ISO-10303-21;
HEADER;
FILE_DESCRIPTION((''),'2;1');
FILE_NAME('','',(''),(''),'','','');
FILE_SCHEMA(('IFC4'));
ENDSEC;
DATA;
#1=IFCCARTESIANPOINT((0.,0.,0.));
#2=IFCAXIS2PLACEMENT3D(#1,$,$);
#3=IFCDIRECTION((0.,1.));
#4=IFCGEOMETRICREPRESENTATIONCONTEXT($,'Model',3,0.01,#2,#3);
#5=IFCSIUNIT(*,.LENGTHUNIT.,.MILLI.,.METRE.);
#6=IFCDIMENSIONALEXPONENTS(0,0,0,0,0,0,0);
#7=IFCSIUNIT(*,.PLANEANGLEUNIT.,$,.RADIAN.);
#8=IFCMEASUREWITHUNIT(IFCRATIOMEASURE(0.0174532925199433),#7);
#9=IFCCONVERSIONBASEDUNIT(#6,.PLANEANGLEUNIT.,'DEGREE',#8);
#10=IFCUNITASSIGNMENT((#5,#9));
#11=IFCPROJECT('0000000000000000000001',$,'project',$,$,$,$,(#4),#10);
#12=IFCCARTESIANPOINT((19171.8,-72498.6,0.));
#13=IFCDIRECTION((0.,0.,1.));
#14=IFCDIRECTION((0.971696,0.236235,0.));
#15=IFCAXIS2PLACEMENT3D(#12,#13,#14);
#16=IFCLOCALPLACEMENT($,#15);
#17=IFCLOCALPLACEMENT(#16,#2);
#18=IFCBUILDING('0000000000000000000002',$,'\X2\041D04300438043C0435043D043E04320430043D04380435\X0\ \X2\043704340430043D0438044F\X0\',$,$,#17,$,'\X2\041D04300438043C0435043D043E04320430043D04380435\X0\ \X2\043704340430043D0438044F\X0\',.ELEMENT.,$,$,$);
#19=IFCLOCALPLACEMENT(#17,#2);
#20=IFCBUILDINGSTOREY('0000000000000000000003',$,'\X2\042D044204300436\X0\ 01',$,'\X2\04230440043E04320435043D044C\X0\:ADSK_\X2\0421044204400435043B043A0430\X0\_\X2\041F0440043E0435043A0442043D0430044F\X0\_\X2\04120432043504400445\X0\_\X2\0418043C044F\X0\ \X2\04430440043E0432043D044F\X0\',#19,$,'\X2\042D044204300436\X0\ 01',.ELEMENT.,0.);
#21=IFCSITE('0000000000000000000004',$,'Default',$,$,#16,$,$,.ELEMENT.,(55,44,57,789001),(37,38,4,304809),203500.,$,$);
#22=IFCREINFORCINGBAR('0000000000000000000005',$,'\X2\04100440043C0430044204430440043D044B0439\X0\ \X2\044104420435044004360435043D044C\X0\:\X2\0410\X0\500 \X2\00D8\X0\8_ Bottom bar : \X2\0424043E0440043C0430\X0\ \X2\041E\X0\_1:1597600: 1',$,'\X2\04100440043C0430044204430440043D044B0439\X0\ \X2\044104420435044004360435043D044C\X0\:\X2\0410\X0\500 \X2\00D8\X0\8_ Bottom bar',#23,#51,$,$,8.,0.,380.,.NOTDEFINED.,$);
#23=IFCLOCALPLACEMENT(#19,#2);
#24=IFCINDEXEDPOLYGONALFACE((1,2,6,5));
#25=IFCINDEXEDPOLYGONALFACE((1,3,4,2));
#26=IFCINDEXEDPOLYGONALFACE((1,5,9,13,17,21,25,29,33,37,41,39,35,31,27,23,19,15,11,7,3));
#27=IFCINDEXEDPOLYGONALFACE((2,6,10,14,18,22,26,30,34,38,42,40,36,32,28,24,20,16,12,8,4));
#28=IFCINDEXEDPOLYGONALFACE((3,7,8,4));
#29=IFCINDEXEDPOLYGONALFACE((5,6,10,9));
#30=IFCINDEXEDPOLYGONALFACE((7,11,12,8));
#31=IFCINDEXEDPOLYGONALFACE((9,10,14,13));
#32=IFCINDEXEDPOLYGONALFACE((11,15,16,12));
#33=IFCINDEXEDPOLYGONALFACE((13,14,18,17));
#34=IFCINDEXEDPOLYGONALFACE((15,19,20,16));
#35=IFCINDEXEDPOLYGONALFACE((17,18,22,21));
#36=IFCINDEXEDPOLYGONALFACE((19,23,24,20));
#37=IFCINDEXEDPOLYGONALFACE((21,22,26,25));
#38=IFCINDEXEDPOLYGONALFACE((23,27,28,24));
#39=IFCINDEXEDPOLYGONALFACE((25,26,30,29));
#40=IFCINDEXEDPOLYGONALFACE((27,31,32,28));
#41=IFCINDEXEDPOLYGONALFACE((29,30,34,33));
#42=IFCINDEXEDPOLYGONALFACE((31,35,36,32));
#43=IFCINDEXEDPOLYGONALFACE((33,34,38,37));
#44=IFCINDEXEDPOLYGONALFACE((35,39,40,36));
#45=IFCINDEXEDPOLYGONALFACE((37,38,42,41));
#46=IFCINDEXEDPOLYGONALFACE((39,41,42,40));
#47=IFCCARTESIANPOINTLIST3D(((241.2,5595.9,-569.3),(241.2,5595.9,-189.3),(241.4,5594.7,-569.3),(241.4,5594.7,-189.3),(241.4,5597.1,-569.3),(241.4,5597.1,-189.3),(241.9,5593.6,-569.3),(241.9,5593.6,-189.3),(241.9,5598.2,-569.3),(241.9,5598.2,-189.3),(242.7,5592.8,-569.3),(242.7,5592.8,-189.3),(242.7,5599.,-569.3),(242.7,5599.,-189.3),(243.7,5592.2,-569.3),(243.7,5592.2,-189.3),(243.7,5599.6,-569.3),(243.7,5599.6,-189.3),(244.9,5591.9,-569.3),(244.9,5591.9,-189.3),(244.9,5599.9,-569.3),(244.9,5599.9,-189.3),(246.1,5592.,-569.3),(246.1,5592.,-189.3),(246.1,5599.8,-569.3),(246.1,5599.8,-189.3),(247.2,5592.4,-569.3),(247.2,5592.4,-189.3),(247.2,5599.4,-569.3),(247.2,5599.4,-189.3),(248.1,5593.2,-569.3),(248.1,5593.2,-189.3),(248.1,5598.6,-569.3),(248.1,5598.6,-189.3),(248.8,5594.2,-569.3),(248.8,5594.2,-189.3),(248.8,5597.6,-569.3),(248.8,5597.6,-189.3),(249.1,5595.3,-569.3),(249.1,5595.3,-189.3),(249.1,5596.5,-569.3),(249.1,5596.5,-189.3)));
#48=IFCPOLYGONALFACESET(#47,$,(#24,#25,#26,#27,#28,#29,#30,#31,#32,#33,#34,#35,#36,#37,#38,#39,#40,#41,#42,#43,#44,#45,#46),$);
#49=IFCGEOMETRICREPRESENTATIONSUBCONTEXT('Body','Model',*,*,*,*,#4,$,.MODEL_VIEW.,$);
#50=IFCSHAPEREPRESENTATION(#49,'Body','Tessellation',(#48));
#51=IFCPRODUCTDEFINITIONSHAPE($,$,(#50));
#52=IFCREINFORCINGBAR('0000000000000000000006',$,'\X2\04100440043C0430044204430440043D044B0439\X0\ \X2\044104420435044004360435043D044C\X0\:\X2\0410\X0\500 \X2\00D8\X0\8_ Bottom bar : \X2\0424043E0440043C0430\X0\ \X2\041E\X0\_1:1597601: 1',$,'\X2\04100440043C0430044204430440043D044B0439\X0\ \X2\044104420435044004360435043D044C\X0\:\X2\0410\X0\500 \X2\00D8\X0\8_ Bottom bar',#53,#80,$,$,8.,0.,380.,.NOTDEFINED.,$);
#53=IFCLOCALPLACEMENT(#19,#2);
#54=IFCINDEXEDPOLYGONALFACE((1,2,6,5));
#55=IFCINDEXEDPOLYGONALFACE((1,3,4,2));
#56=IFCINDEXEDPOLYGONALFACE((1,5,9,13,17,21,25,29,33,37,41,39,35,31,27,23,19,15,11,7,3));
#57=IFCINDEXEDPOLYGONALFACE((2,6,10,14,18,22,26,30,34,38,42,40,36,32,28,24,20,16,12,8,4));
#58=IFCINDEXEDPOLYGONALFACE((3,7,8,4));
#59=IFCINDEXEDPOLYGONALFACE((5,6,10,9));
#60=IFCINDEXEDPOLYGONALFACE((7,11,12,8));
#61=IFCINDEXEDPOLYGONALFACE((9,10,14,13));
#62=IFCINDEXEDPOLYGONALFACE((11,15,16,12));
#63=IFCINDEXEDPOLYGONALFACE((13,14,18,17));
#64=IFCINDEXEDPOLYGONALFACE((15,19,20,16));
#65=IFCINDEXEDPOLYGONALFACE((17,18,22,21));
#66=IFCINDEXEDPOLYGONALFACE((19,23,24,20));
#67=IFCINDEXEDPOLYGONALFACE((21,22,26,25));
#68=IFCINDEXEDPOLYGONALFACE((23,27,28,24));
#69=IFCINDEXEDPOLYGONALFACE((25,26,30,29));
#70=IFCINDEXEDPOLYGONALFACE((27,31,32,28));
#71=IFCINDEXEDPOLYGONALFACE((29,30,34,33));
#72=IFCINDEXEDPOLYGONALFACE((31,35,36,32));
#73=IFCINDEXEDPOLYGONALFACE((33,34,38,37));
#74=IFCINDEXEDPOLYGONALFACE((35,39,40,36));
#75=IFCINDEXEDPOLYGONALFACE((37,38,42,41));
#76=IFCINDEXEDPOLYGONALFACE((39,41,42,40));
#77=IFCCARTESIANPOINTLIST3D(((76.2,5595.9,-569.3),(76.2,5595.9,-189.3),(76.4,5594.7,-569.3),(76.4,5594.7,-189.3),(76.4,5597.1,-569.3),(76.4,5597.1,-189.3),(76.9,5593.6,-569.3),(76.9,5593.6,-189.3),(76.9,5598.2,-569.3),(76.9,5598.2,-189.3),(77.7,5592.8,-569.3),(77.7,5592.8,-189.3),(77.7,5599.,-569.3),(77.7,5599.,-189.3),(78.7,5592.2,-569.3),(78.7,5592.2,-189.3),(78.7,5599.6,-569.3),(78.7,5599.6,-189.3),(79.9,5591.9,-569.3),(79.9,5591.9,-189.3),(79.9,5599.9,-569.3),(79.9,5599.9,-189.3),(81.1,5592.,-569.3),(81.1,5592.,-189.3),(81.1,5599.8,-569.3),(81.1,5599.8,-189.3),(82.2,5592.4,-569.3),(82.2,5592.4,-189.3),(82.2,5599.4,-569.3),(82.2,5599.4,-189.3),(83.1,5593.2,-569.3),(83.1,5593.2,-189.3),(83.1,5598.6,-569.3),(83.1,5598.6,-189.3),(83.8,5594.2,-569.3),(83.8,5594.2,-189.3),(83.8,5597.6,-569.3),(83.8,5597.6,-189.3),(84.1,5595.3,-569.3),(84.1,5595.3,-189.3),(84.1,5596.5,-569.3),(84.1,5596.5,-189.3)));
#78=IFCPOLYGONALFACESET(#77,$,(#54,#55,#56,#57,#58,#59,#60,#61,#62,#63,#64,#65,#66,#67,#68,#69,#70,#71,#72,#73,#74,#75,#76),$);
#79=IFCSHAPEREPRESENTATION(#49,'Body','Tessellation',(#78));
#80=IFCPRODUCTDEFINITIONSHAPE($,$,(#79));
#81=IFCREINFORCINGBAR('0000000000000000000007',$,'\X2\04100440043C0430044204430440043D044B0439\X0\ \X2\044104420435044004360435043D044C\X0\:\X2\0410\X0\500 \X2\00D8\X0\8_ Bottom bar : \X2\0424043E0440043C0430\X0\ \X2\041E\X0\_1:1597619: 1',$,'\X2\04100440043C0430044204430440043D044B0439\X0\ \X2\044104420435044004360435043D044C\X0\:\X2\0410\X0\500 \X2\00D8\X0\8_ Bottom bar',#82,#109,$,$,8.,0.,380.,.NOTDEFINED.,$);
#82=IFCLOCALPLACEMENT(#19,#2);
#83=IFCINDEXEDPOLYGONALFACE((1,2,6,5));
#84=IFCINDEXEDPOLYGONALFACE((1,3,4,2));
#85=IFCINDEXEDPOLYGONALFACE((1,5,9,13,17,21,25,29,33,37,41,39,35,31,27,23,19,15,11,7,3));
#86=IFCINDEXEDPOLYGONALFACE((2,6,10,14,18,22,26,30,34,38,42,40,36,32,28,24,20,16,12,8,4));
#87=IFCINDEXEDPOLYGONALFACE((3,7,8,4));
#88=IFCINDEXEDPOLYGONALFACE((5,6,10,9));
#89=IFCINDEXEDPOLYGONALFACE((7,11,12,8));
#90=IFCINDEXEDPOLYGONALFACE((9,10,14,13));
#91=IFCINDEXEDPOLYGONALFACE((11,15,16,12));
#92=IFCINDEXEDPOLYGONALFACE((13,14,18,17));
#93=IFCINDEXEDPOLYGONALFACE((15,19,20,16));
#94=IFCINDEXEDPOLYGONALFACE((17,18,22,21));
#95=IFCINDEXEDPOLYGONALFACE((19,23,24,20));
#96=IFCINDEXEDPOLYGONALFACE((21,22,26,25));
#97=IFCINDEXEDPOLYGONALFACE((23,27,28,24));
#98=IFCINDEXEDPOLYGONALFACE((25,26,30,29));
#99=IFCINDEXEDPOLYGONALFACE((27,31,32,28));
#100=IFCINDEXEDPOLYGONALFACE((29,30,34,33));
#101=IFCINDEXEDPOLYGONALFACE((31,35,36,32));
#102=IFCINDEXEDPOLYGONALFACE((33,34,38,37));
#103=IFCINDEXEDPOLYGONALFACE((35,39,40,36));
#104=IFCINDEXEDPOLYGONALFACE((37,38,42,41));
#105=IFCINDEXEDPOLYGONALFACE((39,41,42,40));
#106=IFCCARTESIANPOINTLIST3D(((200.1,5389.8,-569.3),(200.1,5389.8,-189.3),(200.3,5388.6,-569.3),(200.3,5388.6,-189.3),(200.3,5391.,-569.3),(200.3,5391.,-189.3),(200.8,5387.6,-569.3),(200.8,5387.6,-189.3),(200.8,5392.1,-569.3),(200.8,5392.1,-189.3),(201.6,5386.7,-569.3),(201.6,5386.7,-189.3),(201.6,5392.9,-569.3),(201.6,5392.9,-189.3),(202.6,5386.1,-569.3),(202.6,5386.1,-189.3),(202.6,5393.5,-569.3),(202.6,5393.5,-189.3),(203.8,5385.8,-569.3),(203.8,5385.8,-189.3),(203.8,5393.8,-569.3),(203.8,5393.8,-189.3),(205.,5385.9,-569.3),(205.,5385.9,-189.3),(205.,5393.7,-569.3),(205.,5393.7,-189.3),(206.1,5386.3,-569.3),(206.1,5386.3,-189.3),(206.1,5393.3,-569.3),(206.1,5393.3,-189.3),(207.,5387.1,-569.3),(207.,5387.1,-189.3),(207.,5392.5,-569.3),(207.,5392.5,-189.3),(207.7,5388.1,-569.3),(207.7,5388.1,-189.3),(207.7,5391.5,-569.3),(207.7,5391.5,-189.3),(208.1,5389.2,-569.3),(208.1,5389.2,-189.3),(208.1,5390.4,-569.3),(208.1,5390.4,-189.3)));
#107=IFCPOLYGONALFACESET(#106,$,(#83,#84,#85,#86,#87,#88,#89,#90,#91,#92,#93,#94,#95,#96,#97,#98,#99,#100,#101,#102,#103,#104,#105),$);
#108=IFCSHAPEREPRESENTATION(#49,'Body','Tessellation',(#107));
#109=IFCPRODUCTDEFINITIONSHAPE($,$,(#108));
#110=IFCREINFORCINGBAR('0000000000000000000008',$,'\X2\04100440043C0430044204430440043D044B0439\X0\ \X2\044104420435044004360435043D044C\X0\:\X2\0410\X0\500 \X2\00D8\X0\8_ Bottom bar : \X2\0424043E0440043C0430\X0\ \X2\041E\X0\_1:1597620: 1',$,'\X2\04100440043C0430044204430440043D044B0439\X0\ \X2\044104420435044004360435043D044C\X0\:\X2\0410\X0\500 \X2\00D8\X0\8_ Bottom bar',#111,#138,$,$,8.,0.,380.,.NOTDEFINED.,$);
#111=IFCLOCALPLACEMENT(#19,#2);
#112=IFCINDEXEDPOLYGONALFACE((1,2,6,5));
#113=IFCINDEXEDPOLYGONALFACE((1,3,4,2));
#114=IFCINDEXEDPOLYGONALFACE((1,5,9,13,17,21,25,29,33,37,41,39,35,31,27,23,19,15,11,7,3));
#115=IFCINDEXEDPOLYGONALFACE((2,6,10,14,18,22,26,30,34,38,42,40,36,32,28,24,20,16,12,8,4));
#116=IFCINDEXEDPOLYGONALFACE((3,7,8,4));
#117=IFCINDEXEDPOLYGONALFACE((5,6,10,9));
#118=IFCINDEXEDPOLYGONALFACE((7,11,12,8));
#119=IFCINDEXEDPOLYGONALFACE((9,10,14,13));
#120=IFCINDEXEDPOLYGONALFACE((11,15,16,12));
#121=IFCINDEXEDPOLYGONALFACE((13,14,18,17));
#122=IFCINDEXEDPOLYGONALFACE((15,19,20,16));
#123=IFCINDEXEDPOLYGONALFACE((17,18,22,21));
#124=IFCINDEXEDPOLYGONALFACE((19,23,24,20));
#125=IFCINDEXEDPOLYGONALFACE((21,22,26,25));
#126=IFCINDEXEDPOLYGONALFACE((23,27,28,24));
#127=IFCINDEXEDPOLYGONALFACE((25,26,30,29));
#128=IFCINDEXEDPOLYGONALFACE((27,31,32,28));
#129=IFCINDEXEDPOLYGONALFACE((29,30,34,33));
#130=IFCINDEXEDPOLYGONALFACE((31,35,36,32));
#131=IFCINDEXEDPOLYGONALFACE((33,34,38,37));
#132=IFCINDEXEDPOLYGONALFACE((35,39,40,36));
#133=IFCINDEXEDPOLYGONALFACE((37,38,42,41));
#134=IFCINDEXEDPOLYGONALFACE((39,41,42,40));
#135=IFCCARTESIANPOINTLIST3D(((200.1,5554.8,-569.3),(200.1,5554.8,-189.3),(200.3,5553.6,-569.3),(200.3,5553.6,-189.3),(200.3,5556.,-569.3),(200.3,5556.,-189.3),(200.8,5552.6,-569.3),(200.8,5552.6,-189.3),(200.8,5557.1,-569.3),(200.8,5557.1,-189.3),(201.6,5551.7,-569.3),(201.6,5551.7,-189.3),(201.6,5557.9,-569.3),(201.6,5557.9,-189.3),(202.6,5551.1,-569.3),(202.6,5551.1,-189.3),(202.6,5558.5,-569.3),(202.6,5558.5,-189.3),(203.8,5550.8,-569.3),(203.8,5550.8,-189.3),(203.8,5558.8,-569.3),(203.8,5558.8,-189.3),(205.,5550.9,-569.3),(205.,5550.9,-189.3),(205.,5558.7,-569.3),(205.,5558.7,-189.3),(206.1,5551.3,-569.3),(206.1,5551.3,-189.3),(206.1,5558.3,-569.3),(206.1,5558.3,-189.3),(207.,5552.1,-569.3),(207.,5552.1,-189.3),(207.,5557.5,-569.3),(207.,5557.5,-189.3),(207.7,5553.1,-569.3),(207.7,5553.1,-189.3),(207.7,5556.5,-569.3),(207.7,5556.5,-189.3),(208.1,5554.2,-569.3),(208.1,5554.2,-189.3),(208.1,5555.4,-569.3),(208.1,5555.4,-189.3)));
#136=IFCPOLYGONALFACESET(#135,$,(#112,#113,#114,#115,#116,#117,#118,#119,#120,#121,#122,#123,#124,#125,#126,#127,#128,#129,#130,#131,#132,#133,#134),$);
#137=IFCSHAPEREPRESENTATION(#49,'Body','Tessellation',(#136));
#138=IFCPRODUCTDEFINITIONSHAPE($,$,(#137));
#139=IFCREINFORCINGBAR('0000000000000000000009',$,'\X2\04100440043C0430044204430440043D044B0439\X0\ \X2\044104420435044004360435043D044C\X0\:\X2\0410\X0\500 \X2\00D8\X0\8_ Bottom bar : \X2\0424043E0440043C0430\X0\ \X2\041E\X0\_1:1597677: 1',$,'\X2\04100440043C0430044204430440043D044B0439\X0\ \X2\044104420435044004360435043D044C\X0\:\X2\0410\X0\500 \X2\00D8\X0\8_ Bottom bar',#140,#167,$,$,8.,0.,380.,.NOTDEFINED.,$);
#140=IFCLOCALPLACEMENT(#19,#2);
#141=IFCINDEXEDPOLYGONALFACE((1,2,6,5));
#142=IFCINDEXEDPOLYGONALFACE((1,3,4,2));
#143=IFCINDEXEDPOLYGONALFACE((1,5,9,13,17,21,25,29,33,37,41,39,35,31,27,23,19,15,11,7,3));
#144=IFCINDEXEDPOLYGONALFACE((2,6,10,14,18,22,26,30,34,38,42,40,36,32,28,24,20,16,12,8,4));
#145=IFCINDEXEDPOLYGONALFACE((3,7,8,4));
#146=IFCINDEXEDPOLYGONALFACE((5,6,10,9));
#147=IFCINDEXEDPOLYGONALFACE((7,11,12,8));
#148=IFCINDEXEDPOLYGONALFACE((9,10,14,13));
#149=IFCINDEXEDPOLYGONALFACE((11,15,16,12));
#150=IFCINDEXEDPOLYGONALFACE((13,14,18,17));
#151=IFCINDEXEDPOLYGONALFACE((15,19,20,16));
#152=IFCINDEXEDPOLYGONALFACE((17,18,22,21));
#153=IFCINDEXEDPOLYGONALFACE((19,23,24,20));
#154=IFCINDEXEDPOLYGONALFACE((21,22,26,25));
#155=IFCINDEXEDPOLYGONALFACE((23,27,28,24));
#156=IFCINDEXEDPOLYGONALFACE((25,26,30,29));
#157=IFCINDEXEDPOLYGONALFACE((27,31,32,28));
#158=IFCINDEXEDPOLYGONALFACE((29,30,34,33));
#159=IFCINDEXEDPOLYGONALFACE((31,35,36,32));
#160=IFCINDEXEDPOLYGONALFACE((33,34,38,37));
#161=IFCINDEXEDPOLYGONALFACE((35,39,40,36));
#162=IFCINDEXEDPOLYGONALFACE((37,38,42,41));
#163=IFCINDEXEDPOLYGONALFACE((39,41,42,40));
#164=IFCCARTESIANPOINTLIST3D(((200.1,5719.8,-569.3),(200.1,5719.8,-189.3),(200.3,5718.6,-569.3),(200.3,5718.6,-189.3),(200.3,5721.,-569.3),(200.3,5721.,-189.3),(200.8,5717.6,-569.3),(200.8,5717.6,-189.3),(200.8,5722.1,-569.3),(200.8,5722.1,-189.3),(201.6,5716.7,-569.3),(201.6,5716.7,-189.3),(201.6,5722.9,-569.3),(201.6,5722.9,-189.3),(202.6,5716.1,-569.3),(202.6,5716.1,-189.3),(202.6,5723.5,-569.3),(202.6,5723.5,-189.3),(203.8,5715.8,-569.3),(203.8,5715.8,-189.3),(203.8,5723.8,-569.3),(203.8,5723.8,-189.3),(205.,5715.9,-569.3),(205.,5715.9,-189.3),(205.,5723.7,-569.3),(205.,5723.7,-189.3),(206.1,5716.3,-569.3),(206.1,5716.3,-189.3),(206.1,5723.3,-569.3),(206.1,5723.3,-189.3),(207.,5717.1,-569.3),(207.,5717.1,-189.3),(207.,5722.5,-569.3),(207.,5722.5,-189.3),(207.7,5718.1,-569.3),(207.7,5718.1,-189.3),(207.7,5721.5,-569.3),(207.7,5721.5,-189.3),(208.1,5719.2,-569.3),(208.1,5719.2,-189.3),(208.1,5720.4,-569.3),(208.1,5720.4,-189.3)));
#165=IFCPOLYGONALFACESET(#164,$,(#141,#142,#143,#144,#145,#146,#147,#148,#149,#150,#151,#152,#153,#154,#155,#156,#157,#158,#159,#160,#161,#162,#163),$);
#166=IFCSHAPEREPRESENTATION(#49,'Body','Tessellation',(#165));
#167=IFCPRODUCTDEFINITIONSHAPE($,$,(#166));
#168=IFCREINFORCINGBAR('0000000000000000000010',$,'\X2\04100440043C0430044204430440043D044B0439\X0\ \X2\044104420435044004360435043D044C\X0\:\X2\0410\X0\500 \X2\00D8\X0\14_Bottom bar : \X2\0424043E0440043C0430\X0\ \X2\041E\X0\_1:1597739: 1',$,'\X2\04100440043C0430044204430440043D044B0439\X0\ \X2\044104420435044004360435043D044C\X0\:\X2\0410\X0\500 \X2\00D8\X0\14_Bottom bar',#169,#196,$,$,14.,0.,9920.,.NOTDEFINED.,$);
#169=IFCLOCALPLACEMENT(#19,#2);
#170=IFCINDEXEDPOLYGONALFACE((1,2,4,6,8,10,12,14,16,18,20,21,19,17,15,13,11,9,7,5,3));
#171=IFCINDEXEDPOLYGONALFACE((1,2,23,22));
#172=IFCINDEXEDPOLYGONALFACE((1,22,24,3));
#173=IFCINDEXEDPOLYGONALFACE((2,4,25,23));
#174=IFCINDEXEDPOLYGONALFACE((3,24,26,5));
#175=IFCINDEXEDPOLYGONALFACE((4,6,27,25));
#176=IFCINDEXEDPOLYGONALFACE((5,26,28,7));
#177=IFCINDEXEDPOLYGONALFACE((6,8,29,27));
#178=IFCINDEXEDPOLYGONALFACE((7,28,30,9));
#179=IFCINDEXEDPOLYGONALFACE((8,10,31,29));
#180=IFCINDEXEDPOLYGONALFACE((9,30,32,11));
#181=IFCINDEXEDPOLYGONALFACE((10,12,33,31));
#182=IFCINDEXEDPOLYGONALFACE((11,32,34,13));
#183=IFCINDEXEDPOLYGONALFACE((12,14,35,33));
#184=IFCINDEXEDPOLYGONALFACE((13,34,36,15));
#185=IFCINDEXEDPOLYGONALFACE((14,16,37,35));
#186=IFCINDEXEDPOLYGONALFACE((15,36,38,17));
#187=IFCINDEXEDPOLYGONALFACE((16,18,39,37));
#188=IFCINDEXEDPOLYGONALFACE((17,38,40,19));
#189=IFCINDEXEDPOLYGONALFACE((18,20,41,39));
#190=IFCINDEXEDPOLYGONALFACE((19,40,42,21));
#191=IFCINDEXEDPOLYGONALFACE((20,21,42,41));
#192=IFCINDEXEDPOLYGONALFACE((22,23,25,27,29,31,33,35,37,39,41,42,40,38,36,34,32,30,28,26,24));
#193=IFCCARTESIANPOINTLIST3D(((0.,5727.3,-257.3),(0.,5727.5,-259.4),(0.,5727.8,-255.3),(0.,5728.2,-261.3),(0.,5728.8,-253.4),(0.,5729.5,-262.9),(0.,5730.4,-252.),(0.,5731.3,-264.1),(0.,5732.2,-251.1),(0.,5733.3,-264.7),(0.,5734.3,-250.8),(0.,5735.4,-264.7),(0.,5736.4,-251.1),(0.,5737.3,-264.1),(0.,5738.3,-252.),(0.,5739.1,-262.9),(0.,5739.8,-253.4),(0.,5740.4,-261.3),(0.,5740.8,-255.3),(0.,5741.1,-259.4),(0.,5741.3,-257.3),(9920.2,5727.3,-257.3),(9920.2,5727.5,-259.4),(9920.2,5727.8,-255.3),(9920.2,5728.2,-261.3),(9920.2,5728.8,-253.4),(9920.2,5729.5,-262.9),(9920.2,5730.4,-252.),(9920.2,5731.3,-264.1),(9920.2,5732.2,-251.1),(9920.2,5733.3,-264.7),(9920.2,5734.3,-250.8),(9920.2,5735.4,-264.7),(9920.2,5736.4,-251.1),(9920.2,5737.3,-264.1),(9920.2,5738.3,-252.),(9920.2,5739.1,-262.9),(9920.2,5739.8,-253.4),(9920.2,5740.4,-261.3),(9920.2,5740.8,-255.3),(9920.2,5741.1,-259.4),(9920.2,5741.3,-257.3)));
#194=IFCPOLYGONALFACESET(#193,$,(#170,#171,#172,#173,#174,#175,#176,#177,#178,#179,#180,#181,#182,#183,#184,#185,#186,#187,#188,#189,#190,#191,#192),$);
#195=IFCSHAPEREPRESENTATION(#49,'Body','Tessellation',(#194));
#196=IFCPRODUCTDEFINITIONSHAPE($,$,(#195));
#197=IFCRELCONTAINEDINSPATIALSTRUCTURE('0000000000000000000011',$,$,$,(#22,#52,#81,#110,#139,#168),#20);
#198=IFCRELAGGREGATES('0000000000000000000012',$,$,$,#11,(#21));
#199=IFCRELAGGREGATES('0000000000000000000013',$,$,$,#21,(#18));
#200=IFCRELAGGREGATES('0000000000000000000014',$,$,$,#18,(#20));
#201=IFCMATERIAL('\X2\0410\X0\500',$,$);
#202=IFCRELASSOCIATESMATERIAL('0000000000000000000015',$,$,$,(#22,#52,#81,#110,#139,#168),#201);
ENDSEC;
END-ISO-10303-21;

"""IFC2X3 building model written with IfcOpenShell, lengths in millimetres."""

from ifc_helpers import new_model, entity, si_unit, converted_unit, direction, frame, origin, place, context, subcontext, project, spatial, material, element, save


model = new_model("IFC2X3")

# Units and contexts
model_context = context("Model", 3, precision=0.01, world=origin(), true_north=direction((0.0, 1.0)))
body_context = subcontext(model_context, "Body", "Model", "MODEL_VIEW")
ifc_project = project(units=[si_unit("LENGTHUNIT", "METRE", prefix="MILLI"), converted_unit("PLANEANGLEUNIT", "DEGREE", entity("IfcRatioMeasure", 0.0174532925199433), si_unit("PLANEANGLEUNIT", "RADIAN"), dimensions=[0, 0, 0, 0, 0, 0, 0])], contexts=[model_context])

# Site, building, storey
site_placement = place(None, frame((19171.8, -72498.6, 0.0), z_axis=(0.0, 0.0, 1.0), x_axis=(0.971696, 0.236235, 0.0)))
site = spatial("IfcSite", under=ifc_project, at=site_placement, Name="Default", CompositionType="ELEMENT", RefLatitude=(55, 44, 57, 789001), RefLongitude=(37, 38, 4, 304809), RefElevation=203500.0)
building_placement = place(site_placement, origin())
building = spatial("IfcBuilding", under=site, at=building_placement, Name="Наименование здания", LongName="Наименование здания", CompositionType="ELEMENT")
storey_placement = place(building_placement, origin())
storey = spatial("IfcBuildingStorey", under=building, at=storey_placement, Name="Этаж 01", ObjectType="Уровень:ADSK_Стрелка_Проектная_Вверх_Имя уровня", LongName="Этаж 01", CompositionType="ELEMENT", Elevation=0.0)

# Reinforcing bars
ifc_material = material(Name="А500")
placement = place(storey_placement, origin())
element("IfcReinforcingBar", 1, at=placement, inside=storey, material=ifc_material, Name="Арматурный стержень:А500 Ø8_ Bottom bar : Форма О_1:1597600: 1", ObjectType="Арматурный стержень:А500 Ø8_ Bottom bar", BarLength=380.0, BarRole="NOTDEFINED", CrossSectionArea=0.0, NominalDiameter=8.0, context=body_context, shape_type="AdvancedSweptSolid", body=[
    entity("IfcSweptDiskSolid", entity("IfcCompositeCurve", [entity("IfcCompositeCurveSegment", "CONTINUOUS", True, entity("IfcPolyline", [entity("IfcCartesianPoint", [245.2, 5595.9, -189.3]), entity("IfcCartesianPoint", [245.2, 5595.9, -569.3])]))], False), 4.0, None, 0.0, 1.0),
])
element("IfcReinforcingBar", 2, at=placement, inside=storey, material=ifc_material, Name="Арматурный стержень:А500 Ø8_ Bottom bar : Форма О_1:1597601: 1", ObjectType="Арматурный стержень:А500 Ø8_ Bottom bar", BarLength=380.0, BarRole="NOTDEFINED", CrossSectionArea=0.0, NominalDiameter=8.0, context=body_context, shape_type="AdvancedSweptSolid", body=[
    entity("IfcSweptDiskSolid", entity("IfcCompositeCurve", [entity("IfcCompositeCurveSegment", "CONTINUOUS", True, entity("IfcPolyline", [entity("IfcCartesianPoint", [80.2, 5595.9, -189.3]), entity("IfcCartesianPoint", [80.2, 5595.9, -569.3])]))], False), 4.0, None, 0.0, 1.0),
])
element("IfcReinforcingBar", 3, at=placement, inside=storey, material=ifc_material, Name="Арматурный стержень:А500 Ø8_ Bottom bar : Форма О_1:1597619: 1", ObjectType="Арматурный стержень:А500 Ø8_ Bottom bar", BarLength=380.0, BarRole="NOTDEFINED", CrossSectionArea=0.0, NominalDiameter=8.0, context=body_context, shape_type="AdvancedSweptSolid", body=[
    entity("IfcSweptDiskSolid", entity("IfcCompositeCurve", [entity("IfcCompositeCurveSegment", "CONTINUOUS", True, entity("IfcPolyline", [entity("IfcCartesianPoint", [204.1, 5389.8, -189.3]), entity("IfcCartesianPoint", [204.1, 5389.8, -569.3])]))], False), 4.0, None, 0.0, 1.0),
])
element("IfcReinforcingBar", 4, at=placement, inside=storey, material=ifc_material, Name="Арматурный стержень:А500 Ø8_ Bottom bar : Форма О_1:1597620: 1", ObjectType="Арматурный стержень:А500 Ø8_ Bottom bar", BarLength=380.0, BarRole="NOTDEFINED", CrossSectionArea=0.0, NominalDiameter=8.0, context=body_context, shape_type="AdvancedSweptSolid", body=[
    entity("IfcSweptDiskSolid", entity("IfcCompositeCurve", [entity("IfcCompositeCurveSegment", "CONTINUOUS", True, entity("IfcPolyline", [entity("IfcCartesianPoint", [204.1, 5554.8, -189.3]), entity("IfcCartesianPoint", [204.1, 5554.8, -569.3])]))], False), 4.0, None, 0.0, 1.0),
])
element("IfcReinforcingBar", 5, at=placement, inside=storey, material=ifc_material, Name="Арматурный стержень:А500 Ø8_ Bottom bar : Форма О_1:1597677: 1", ObjectType="Арматурный стержень:А500 Ø8_ Bottom bar", BarLength=380.0, BarRole="NOTDEFINED", CrossSectionArea=0.0, NominalDiameter=8.0, context=body_context, shape_type="AdvancedSweptSolid", body=[
    entity("IfcSweptDiskSolid", entity("IfcCompositeCurve", [entity("IfcCompositeCurveSegment", "CONTINUOUS", True, entity("IfcPolyline", [entity("IfcCartesianPoint", [204.1, 5719.8, -189.3]), entity("IfcCartesianPoint", [204.1, 5719.8, -569.3])]))], False), 4.0, None, 0.0, 1.0),
])
element("IfcReinforcingBar", 6, at=placement, inside=storey, material=ifc_material, Name="Арматурный стержень:А500 Ø14_Bottom bar : Форма О_1:1597739: 1", ObjectType="Арматурный стержень:А500 Ø14_Bottom bar", BarLength=9920.0, BarRole="NOTDEFINED", CrossSectionArea=0.0, NominalDiameter=14.0, context=body_context, shape_type="AdvancedSweptSolid", body=[
    entity("IfcSweptDiskSolid", entity("IfcCompositeCurve", [entity("IfcCompositeCurveSegment", "CONTINUOUS", True, entity("IfcPolyline", [entity("IfcCartesianPoint", [0.0, 5734.3, -257.8]), entity("IfcCartesianPoint", [9920.2, 5734.3, -257.8])]))], False), 7.0, None, 0.0, 1.0),
])

save(model, "model.ifc")
